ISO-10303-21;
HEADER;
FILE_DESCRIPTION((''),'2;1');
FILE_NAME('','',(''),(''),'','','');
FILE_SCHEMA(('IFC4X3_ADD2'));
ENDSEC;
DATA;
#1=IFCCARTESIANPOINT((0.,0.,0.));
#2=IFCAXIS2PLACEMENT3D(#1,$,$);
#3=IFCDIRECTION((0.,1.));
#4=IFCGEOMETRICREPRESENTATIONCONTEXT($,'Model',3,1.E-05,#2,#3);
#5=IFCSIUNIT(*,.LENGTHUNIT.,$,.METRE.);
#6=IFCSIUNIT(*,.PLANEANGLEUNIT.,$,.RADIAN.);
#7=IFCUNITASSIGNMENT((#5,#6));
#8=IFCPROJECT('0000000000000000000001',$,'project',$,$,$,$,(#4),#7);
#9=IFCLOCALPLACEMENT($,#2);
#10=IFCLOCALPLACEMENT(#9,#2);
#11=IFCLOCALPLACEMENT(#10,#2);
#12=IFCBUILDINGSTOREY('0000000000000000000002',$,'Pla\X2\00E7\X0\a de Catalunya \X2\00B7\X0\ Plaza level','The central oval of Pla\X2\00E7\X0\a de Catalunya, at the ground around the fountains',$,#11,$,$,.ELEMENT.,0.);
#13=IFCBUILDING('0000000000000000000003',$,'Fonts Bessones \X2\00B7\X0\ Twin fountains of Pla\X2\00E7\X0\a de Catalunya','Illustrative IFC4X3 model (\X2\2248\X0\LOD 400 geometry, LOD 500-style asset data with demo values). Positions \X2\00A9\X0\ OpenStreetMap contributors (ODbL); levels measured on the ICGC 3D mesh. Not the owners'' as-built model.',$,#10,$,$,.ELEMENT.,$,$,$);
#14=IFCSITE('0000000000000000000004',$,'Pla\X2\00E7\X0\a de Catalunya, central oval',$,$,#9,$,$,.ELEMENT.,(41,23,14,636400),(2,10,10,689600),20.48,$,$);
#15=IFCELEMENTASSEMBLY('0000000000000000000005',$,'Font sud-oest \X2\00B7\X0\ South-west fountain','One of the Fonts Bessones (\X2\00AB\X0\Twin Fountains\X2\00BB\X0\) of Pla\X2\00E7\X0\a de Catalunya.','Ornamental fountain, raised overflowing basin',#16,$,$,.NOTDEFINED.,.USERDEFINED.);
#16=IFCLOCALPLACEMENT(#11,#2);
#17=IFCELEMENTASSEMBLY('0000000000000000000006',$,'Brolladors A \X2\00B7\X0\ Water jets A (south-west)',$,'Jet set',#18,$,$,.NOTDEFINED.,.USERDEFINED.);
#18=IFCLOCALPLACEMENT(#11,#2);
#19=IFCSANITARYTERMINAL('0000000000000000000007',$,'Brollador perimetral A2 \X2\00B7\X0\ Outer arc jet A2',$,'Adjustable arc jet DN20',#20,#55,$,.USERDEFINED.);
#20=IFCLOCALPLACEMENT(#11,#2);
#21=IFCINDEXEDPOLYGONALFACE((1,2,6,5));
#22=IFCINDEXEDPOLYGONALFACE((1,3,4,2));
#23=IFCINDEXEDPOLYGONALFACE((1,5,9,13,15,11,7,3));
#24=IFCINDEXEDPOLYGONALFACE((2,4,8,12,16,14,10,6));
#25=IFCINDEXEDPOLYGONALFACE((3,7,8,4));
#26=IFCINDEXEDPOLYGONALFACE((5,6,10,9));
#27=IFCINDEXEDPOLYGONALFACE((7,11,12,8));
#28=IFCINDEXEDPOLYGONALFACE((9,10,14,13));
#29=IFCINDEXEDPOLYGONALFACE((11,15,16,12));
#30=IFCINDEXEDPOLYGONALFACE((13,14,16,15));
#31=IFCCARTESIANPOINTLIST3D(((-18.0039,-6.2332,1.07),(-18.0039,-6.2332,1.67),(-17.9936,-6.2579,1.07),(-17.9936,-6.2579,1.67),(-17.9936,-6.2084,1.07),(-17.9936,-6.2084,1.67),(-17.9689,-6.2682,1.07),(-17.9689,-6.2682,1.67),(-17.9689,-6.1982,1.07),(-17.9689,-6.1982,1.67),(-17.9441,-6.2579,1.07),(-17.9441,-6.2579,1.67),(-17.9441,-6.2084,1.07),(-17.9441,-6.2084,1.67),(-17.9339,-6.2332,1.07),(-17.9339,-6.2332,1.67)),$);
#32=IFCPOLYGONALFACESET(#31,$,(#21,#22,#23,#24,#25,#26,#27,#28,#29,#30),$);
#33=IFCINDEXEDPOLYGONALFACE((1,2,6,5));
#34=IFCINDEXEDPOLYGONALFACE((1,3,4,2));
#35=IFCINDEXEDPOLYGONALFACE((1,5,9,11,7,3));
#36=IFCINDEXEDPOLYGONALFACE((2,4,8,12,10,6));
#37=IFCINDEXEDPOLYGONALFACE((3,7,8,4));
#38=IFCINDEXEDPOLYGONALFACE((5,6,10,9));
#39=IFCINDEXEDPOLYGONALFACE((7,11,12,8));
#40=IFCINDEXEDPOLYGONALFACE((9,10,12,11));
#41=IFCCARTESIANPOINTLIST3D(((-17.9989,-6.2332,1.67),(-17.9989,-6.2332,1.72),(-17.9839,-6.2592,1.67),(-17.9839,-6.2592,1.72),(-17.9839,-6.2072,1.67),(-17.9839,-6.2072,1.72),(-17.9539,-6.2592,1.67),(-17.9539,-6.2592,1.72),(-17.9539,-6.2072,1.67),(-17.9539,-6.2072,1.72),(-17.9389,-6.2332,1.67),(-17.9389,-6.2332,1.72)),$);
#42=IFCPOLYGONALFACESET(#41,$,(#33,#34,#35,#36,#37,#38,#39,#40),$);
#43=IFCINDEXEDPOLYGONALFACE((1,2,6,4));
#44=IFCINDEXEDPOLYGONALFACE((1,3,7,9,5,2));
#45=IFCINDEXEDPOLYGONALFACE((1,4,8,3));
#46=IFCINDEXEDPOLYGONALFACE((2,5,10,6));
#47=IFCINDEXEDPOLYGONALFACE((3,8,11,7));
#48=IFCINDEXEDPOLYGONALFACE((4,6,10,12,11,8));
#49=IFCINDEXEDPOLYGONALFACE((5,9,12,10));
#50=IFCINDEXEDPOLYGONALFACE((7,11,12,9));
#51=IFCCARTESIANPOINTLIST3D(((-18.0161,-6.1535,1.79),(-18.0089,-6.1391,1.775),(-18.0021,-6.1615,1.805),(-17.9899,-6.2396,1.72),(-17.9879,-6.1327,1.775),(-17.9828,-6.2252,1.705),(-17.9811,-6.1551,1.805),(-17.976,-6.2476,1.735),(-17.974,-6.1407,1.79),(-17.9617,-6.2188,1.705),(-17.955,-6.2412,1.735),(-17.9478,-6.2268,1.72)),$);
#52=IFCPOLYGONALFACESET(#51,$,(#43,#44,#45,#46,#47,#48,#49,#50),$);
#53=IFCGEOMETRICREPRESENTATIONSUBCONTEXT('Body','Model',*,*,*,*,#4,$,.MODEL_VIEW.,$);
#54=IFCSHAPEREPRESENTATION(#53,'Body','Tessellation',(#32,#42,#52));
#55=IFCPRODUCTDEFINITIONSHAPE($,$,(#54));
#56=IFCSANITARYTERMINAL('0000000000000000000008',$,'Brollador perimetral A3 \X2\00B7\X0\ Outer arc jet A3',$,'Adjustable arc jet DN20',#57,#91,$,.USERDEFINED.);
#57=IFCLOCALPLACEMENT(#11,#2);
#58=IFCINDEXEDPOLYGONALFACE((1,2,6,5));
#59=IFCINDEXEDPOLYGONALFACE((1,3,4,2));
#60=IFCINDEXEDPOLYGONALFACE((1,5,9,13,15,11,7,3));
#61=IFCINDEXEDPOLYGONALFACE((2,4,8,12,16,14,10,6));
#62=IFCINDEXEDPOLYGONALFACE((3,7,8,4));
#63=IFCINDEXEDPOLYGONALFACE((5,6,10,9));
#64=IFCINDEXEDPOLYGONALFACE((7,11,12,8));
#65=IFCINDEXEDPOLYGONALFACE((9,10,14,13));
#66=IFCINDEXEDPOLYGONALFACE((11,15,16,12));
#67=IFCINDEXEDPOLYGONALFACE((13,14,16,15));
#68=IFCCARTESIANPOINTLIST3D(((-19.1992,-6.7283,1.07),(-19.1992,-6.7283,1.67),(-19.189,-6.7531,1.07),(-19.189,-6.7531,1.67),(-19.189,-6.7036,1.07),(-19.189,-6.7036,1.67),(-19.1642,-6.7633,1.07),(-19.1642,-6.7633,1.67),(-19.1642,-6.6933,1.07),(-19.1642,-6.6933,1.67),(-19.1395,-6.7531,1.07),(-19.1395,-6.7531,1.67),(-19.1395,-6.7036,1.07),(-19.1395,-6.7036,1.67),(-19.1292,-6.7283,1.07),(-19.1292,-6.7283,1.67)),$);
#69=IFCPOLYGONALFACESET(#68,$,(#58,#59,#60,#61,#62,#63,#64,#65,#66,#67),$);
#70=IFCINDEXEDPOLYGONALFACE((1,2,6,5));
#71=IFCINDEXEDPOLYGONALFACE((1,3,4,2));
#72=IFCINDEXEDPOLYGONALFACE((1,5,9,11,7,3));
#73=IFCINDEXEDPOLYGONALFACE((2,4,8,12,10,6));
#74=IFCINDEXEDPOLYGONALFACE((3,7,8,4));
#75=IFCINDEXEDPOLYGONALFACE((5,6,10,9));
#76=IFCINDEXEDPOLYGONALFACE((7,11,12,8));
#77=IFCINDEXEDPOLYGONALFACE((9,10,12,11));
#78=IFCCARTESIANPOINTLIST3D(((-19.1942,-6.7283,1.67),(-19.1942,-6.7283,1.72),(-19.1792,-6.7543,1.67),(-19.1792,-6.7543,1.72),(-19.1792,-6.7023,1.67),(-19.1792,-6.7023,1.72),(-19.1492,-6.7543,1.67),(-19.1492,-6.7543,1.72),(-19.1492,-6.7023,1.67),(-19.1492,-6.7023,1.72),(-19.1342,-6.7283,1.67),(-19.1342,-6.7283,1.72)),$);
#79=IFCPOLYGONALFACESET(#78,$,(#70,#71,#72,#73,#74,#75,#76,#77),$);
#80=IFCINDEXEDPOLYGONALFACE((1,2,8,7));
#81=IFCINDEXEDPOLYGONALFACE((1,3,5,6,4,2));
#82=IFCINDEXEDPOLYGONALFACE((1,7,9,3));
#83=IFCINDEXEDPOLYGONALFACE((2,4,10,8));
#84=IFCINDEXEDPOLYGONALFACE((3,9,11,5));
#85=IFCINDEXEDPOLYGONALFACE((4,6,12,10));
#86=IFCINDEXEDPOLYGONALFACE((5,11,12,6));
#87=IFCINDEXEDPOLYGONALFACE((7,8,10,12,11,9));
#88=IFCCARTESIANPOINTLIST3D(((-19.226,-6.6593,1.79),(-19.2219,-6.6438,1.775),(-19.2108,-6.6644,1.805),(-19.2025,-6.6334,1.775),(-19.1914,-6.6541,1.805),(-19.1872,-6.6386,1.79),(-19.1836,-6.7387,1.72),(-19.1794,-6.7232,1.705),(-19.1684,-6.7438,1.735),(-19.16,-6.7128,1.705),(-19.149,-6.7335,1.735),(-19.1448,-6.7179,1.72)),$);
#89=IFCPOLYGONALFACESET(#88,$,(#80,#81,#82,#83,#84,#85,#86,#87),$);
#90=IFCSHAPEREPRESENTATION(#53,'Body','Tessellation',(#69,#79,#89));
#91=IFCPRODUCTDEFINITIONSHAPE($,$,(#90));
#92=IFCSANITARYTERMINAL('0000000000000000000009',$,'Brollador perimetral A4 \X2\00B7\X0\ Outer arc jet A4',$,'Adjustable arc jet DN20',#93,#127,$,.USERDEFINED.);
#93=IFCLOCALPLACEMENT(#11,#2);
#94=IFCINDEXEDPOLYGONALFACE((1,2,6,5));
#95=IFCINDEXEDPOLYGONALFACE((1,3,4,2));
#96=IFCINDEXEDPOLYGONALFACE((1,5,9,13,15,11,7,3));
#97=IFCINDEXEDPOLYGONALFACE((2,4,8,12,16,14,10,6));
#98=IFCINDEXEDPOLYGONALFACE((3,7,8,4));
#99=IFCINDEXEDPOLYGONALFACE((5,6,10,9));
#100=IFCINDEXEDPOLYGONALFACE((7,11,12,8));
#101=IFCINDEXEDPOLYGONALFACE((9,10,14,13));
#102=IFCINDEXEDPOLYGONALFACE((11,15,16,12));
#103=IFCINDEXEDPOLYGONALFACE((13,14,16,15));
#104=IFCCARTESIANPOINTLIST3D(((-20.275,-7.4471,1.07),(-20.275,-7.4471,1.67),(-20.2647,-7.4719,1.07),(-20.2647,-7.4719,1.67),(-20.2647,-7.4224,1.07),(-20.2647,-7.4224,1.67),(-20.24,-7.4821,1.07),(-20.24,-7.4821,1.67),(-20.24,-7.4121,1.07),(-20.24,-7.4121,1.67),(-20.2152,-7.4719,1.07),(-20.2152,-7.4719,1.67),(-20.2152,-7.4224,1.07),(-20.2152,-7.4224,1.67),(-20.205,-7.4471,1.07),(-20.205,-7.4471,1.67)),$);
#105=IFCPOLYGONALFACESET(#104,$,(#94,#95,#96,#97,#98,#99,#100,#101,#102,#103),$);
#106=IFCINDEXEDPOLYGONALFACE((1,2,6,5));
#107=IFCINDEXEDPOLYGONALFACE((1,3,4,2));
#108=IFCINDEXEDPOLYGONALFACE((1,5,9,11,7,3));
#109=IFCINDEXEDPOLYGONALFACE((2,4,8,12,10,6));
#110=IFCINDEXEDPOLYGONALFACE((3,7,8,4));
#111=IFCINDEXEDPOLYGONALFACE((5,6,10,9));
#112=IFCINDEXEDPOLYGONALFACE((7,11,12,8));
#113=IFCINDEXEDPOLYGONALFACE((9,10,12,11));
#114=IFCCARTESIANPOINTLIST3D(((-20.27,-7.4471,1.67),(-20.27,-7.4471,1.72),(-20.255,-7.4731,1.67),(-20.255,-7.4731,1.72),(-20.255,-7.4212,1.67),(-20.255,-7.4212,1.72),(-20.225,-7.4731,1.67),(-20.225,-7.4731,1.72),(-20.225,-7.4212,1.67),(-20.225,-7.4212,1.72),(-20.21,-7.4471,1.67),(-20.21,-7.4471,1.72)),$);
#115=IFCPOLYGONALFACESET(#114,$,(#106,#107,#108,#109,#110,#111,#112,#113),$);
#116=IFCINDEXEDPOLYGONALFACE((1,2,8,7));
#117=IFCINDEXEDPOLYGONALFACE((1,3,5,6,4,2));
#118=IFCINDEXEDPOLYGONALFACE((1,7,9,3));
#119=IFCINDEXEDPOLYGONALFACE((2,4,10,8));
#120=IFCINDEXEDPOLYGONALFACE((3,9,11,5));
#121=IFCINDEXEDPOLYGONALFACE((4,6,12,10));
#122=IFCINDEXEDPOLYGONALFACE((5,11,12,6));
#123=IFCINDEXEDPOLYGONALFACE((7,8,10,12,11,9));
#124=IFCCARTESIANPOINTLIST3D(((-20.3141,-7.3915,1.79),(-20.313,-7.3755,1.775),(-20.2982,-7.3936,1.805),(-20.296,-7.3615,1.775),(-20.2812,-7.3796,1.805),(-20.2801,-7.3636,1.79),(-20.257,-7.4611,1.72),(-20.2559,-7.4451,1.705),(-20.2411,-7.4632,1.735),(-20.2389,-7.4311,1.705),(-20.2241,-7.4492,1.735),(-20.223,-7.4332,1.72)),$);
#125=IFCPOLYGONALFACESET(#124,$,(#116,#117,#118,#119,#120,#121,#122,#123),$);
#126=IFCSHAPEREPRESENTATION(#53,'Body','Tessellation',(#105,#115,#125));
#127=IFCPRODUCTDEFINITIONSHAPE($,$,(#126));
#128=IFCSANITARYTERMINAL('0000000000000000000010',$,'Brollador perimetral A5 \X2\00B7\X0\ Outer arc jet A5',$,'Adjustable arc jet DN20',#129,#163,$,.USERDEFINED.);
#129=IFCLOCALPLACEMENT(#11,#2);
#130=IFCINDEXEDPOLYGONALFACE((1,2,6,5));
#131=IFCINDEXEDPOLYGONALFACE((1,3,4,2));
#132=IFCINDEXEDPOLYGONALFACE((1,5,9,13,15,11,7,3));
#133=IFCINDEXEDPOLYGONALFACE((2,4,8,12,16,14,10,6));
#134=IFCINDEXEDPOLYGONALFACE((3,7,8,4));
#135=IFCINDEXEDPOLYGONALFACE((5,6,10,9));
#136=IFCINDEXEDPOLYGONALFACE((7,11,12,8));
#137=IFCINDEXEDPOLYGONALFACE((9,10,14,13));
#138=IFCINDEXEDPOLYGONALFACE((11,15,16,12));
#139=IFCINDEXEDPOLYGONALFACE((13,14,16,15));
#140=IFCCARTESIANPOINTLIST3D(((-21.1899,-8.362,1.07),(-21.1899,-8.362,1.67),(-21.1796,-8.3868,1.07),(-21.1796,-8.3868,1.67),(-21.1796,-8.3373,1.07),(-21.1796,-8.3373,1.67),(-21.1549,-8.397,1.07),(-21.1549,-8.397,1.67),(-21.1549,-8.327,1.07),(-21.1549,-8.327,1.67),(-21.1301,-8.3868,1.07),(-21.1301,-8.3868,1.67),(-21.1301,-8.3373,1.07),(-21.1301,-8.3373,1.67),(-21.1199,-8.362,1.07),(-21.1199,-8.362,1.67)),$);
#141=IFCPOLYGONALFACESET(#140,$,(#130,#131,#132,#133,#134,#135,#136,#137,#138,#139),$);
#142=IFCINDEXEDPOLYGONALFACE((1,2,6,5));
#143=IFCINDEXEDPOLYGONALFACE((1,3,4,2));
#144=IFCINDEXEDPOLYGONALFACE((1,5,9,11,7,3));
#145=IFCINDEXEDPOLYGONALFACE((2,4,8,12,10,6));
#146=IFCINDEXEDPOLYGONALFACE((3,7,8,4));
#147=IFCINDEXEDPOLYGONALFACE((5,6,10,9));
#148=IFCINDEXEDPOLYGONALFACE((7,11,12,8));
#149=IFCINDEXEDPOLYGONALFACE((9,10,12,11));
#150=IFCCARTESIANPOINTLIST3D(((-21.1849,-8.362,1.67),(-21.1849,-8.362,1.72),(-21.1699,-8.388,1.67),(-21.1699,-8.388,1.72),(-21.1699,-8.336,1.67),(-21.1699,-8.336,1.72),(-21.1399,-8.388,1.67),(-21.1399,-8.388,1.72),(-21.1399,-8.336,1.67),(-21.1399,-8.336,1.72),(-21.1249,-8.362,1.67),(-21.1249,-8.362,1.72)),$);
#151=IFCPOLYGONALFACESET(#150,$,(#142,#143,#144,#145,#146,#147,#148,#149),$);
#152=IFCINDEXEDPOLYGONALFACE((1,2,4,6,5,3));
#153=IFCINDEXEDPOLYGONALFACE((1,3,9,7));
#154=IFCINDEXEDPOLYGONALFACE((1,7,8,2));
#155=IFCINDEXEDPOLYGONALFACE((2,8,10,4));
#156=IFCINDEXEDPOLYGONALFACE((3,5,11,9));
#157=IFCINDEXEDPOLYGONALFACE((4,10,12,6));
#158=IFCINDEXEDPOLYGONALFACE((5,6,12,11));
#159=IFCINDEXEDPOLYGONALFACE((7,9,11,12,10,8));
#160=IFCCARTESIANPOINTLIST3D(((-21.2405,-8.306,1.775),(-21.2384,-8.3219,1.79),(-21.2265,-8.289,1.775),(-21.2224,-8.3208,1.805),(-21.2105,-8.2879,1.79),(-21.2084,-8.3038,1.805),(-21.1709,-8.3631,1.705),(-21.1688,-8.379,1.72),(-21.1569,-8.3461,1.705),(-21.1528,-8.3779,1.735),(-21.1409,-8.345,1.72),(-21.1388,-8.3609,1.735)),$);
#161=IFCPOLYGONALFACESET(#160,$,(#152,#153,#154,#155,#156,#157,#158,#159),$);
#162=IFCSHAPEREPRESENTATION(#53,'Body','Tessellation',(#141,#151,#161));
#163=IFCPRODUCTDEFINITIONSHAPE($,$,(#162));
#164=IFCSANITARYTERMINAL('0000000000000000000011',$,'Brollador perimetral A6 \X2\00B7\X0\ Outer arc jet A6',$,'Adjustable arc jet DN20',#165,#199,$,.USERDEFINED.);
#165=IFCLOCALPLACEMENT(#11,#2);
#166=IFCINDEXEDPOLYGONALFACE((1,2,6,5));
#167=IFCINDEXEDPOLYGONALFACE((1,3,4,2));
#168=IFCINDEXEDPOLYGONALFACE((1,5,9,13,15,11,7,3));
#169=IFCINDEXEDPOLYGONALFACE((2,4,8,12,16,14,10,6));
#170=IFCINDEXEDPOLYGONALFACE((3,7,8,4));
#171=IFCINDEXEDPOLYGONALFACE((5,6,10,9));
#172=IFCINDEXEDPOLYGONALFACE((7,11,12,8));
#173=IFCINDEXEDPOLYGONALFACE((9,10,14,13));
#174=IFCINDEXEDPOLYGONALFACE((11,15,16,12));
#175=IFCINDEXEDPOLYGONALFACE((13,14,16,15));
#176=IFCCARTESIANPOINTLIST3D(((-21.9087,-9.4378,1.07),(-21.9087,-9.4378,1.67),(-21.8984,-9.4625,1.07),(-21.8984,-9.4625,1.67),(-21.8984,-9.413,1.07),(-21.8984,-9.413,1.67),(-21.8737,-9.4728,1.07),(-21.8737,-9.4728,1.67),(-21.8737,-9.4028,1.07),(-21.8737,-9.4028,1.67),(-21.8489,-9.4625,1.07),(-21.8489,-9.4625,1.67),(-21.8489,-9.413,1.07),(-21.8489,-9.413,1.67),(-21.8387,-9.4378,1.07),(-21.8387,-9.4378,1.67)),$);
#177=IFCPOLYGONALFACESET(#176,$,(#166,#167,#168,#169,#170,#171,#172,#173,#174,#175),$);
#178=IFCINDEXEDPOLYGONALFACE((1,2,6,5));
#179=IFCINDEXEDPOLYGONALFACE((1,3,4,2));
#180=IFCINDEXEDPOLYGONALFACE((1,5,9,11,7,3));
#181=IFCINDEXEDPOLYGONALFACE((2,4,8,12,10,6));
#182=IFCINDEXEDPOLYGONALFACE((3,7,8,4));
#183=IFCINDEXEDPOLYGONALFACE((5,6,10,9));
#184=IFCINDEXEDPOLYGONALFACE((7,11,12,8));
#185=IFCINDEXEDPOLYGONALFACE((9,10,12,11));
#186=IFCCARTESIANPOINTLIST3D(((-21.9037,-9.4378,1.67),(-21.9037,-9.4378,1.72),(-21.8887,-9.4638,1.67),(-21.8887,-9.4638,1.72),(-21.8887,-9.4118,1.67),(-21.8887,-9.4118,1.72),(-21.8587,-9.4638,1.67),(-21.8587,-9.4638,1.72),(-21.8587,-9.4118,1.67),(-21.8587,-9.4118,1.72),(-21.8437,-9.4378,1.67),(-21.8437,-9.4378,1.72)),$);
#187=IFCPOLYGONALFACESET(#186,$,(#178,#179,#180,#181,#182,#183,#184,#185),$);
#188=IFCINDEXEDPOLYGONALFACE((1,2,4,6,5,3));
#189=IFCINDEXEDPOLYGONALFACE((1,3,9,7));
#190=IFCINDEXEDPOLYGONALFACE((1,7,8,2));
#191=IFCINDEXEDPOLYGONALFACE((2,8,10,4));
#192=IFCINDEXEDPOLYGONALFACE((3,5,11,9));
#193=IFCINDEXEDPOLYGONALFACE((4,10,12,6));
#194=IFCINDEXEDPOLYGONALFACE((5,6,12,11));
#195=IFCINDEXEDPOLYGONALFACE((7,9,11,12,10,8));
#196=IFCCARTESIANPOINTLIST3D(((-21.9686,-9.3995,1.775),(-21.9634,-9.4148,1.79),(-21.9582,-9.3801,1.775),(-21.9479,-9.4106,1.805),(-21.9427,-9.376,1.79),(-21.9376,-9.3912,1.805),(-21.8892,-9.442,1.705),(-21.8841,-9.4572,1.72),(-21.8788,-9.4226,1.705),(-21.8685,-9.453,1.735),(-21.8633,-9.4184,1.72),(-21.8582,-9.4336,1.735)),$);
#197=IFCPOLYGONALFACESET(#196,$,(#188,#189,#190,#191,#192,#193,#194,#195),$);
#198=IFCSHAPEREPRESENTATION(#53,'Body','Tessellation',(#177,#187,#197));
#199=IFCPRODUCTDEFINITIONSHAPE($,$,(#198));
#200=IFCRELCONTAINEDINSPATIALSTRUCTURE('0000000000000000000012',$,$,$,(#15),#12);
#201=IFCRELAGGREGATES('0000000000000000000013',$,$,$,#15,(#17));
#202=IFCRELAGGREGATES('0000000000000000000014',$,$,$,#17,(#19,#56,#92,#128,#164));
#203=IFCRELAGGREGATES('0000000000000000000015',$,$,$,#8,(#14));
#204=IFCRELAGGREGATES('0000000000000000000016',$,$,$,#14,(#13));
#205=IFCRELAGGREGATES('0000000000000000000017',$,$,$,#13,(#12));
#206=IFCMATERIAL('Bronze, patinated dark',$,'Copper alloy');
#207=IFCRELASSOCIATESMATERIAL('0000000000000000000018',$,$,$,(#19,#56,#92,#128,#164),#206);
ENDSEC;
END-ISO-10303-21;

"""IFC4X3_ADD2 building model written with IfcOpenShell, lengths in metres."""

from ifc_helpers import new_model, si_unit, direction, frame, origin, place, context, subcontext, project, spatial, polyline, outline, extrude, material, element, aggregate, save


model = new_model("IFC4X3_ADD2")

# Units and contexts
model_context = context("Model", 3, precision=1e-05, world=origin(), true_north=direction((0.0, 1.0)))
body_context = subcontext(model_context, "Body", "Model", "MODEL_VIEW")
ifc_project = project(units=[si_unit("LENGTHUNIT", "METRE"), si_unit("PLANEANGLEUNIT", "RADIAN")], contexts=[model_context])

# Site, building, storey
site_placement = place(None, origin())
site = spatial("IfcSite", under=ifc_project, at=site_placement, Name="Plaça de Catalunya, central oval", CompositionType="ELEMENT", RefLatitude=(41, 23, 14, 636400), RefLongitude=(2, 10, 10, 689600), RefElevation=20.48)
building_placement = place(site_placement, origin())
building = spatial("IfcBuilding", under=site, at=building_placement, Name="Fonts Bessones · Twin fountains of Plaça de Catalunya", Description="Illustrative IFC4X3 model (≈LOD 400 geometry, LOD 500-style asset data with demo values). Positions © OpenStreetMap contributors (ODbL); levels measured on the ICGC 3D mesh. Not the owners' as-built model.", CompositionType="ELEMENT")
storey_placement = place(building_placement, origin())
storey = spatial("IfcBuildingStorey", under=building, at=storey_placement, Name="Plaça de Catalunya · Plaza level", Description="The central oval of Plaça de Catalunya, at the ground around the fountains", CompositionType="ELEMENT", Elevation=0.0)

# Element assemblies, sanitary terminals
assembly_1_placement = place(building_placement, origin())
assembly_1 = element("IfcElementAssembly", 1, at=assembly_1_placement, inside=storey, Name="Font sud-oest · South-west fountain", Description="One of the Fonts Bessones («Twin Fountains») of Plaça de Catalunya.", ObjectType="Ornamental fountain, raised overflowing basin", AssemblyPlace="NOTDEFINED", PredefinedType="USERDEFINED")
assembly_2_placement = place(building_placement, origin())
assembly_2 = element("IfcElementAssembly", 2, at=assembly_2_placement, Name="Brolladors A · Water jets A (south-west)", ObjectType="Jet set", AssemblyPlace="NOTDEFINED", PredefinedType="USERDEFINED")
aggregate(assembly_1, [assembly_2])
ifc_material = material(Name="Bronze, patinated dark", Category="Copper alloy")
sanitary_terminal_1_placement = place(building_placement, origin())
sanitary_terminal_1 = element("IfcSanitaryTerminal", 3, at=sanitary_terminal_1_placement, material=ifc_material, Name="Brollador perimetral A2 · Outer arc jet A2", ObjectType="Adjustable arc jet DN20", PredefinedType="USERDEFINED", context=body_context, shape_type="SweptSolid", body=[
    extrude(outline(polyline([(-17.9339, -6.2332), (-17.9441, -6.2084), (-17.9689, -6.1982), (-17.9936, -6.2084), (-18.0039, -6.2332), (-17.9936, -6.2579), (-17.9689, -6.2682), (-17.9441, -6.2579), (-17.9339, -6.2332)])), frame((0.0, 0.0, 1.07)), (0.0, 0.0, 1.0), 0.6),
    extrude(outline(polyline([(-17.9389, -6.2332), (-17.9539, -6.2072), (-17.9839, -6.2072), (-17.9989, -6.2332), (-17.9839, -6.2592), (-17.9539, -6.2592), (-17.9389, -6.2332)])), frame((0.0, 0.0, 1.67)), (0.0, 0.0, 1.0), 0.05),
    extrude(outline(polyline([(0.022, 0.0), (0.011, 0.0191), (-0.011, 0.0191), (-0.022, 0.0), (-0.011, -0.0191), (0.011, -0.0191), (0.022, 0.0)])), frame((-17.9689, -6.2332, 1.72), z_axis=(-0.229137, 0.755363, 0.613941), x_axis=(0.95694, 0.290285, 0.0)), (0.0, 0.0, 1.0), 0.114),
])
sanitary_terminal_2_placement = place(building_placement, origin())
sanitary_terminal_2 = element("IfcSanitaryTerminal", 4, at=sanitary_terminal_2_placement, material=ifc_material, Name="Brollador perimetral A3 · Outer arc jet A3", ObjectType="Adjustable arc jet DN20", PredefinedType="USERDEFINED", context=body_context, shape_type="SweptSolid", body=[
    extrude(outline(polyline([(-19.1292, -6.7283), (-19.1395, -6.7036), (-19.1642, -6.6933), (-19.189, -6.7036), (-19.1992, -6.7283), (-19.189, -6.7531), (-19.1642, -6.7633), (-19.1395, -6.7531), (-19.1292, -6.7283)])), frame((0.0, 0.0, 1.07)), (0.0, 0.0, 1.0), 0.6),
    extrude(outline(polyline([(-19.1342, -6.7283), (-19.1492, -6.7023), (-19.1792, -6.7023), (-19.1942, -6.7283), (-19.1792, -6.7543), (-19.1492, -6.7543), (-19.1342, -6.7283)])), frame((0.0, 0.0, 1.67)), (0.0, 0.0, 1.0), 0.05),
    extrude(outline(polyline([(0.022, 0.0), (0.011, 0.0191), (-0.011, 0.0191), (-0.022, 0.0), (-0.011, -0.0191), (0.011, -0.0191), (0.022, 0.0)])), frame((-19.1642, -6.7283, 1.72), z_axis=(-0.372098, 0.696147, 0.613941), x_axis=(0.881921, 0.471397, 0.0)), (0.0, 0.0, 1.0), 0.114),
])
sanitary_terminal_3_placement = place(building_placement, origin())
sanitary_terminal_3 = element("IfcSanitaryTerminal", 5, at=sanitary_terminal_3_placement, material=ifc_material, Name="Brollador perimetral A4 · Outer arc jet A4", ObjectType="Adjustable arc jet DN20", PredefinedType="USERDEFINED", context=body_context, shape_type="SweptSolid", body=[
    extrude(outline(polyline([(-20.205, -7.4471), (-20.2152, -7.4224), (-20.24, -7.4121), (-20.2647, -7.4224), (-20.275, -7.4471), (-20.2647, -7.4719), (-20.24, -7.4821), (-20.2152, -7.4719), (-20.205, -7.4471)])), frame((0.0, 0.0, 1.07)), (0.0, 0.0, 1.0), 0.6),
    extrude(outline(polyline([(-20.21, -7.4471), (-20.225, -7.4212), (-20.255, -7.4212), (-20.27, -7.4471), (-20.255, -7.4731), (-20.225, -7.4731), (-20.21, -7.4471)])), frame((0.0, 0.0, 1.67)), (0.0, 0.0, 1.0), 0.05),
    extrude(outline(polyline([(0.022, 0.0), (0.011, 0.0191), (-0.011, 0.0191), (-0.022, 0.0), (-0.011, -0.0191), (0.011, -0.0191), (0.022, 0.0)])), frame((-20.24, -7.4471, 1.72), z_axis=(-0.50076, 0.610178, 0.613941), x_axis=(0.77301, 0.634393, 0.0)), (0.0, 0.0, 1.0), 0.114),
])
sanitary_terminal_4_placement = place(building_placement, origin())
sanitary_terminal_4 = element("IfcSanitaryTerminal", 6, at=sanitary_terminal_4_placement, material=ifc_material, Name="Brollador perimetral A5 · Outer arc jet A5", ObjectType="Adjustable arc jet DN20", PredefinedType="USERDEFINED", context=body_context, shape_type="SweptSolid", body=[
    extrude(outline(polyline([(-21.1199, -8.362), (-21.1301, -8.3373), (-21.1549, -8.327), (-21.1796, -8.3373), (-21.1899, -8.362), (-21.1796, -8.3868), (-21.1549, -8.397), (-21.1301, -8.3868), (-21.1199, -8.362)])), frame((0.0, 0.0, 1.07)), (0.0, 0.0, 1.0), 0.6),
    extrude(outline(polyline([(-21.1249, -8.362), (-21.1399, -8.336), (-21.1699, -8.336), (-21.1849, -8.362), (-21.1699, -8.388), (-21.1399, -8.388), (-21.1249, -8.362)])), frame((0.0, 0.0, 1.67)), (0.0, 0.0, 1.0), 0.05),
    extrude(outline(polyline([(0.022, 0.0), (0.011, 0.0191), (-0.011, 0.0191), (-0.022, 0.0), (-0.011, -0.0191), (0.011, -0.0191), (0.022, 0.0)])), frame((-21.1549, -8.362, 1.72), z_axis=(-0.610178, 0.50076, 0.613941), x_axis=(0.634393, 0.77301, 0.0)), (0.0, 0.0, 1.0), 0.114),
])
sanitary_terminal_5_placement = place(building_placement, origin())
sanitary_terminal_5 = element("IfcSanitaryTerminal", 7, at=sanitary_terminal_5_placement, material=ifc_material, Name="Brollador perimetral A6 · Outer arc jet A6", ObjectType="Adjustable arc jet DN20", PredefinedType="USERDEFINED", context=body_context, shape_type="SweptSolid", body=[
    extrude(outline(polyline([(-21.8387, -9.4378), (-21.8489, -9.413), (-21.8737, -9.4028), (-21.8984, -9.413), (-21.9087, -9.4378), (-21.8984, -9.4625), (-21.8737, -9.4728), (-21.8489, -9.4625), (-21.8387, -9.4378)])), frame((0.0, 0.0, 1.07)), (0.0, 0.0, 1.0), 0.6),
    extrude(outline(polyline([(-21.8437, -9.4378), (-21.8587, -9.4118), (-21.8887, -9.4118), (-21.9037, -9.4378), (-21.8887, -9.4638), (-21.8587, -9.4638), (-21.8437, -9.4378)])), frame((0.0, 0.0, 1.67)), (0.0, 0.0, 1.0), 0.05),
    extrude(outline(polyline([(0.022, 0.0), (0.011, 0.0191), (-0.011, 0.0191), (-0.022, 0.0), (-0.011, -0.0191), (0.011, -0.0191), (0.022, 0.0)])), frame((-21.8737, -9.4378, 1.72), z_axis=(-0.696147, 0.372098, 0.613941), x_axis=(0.471397, 0.881921, 0.0)), (0.0, 0.0, 1.0), 0.114),
])
aggregate(assembly_2, [sanitary_terminal_1, sanitary_terminal_2, sanitary_terminal_3, sanitary_terminal_4, sanitary_terminal_5])

save(model, "model.ifc")
